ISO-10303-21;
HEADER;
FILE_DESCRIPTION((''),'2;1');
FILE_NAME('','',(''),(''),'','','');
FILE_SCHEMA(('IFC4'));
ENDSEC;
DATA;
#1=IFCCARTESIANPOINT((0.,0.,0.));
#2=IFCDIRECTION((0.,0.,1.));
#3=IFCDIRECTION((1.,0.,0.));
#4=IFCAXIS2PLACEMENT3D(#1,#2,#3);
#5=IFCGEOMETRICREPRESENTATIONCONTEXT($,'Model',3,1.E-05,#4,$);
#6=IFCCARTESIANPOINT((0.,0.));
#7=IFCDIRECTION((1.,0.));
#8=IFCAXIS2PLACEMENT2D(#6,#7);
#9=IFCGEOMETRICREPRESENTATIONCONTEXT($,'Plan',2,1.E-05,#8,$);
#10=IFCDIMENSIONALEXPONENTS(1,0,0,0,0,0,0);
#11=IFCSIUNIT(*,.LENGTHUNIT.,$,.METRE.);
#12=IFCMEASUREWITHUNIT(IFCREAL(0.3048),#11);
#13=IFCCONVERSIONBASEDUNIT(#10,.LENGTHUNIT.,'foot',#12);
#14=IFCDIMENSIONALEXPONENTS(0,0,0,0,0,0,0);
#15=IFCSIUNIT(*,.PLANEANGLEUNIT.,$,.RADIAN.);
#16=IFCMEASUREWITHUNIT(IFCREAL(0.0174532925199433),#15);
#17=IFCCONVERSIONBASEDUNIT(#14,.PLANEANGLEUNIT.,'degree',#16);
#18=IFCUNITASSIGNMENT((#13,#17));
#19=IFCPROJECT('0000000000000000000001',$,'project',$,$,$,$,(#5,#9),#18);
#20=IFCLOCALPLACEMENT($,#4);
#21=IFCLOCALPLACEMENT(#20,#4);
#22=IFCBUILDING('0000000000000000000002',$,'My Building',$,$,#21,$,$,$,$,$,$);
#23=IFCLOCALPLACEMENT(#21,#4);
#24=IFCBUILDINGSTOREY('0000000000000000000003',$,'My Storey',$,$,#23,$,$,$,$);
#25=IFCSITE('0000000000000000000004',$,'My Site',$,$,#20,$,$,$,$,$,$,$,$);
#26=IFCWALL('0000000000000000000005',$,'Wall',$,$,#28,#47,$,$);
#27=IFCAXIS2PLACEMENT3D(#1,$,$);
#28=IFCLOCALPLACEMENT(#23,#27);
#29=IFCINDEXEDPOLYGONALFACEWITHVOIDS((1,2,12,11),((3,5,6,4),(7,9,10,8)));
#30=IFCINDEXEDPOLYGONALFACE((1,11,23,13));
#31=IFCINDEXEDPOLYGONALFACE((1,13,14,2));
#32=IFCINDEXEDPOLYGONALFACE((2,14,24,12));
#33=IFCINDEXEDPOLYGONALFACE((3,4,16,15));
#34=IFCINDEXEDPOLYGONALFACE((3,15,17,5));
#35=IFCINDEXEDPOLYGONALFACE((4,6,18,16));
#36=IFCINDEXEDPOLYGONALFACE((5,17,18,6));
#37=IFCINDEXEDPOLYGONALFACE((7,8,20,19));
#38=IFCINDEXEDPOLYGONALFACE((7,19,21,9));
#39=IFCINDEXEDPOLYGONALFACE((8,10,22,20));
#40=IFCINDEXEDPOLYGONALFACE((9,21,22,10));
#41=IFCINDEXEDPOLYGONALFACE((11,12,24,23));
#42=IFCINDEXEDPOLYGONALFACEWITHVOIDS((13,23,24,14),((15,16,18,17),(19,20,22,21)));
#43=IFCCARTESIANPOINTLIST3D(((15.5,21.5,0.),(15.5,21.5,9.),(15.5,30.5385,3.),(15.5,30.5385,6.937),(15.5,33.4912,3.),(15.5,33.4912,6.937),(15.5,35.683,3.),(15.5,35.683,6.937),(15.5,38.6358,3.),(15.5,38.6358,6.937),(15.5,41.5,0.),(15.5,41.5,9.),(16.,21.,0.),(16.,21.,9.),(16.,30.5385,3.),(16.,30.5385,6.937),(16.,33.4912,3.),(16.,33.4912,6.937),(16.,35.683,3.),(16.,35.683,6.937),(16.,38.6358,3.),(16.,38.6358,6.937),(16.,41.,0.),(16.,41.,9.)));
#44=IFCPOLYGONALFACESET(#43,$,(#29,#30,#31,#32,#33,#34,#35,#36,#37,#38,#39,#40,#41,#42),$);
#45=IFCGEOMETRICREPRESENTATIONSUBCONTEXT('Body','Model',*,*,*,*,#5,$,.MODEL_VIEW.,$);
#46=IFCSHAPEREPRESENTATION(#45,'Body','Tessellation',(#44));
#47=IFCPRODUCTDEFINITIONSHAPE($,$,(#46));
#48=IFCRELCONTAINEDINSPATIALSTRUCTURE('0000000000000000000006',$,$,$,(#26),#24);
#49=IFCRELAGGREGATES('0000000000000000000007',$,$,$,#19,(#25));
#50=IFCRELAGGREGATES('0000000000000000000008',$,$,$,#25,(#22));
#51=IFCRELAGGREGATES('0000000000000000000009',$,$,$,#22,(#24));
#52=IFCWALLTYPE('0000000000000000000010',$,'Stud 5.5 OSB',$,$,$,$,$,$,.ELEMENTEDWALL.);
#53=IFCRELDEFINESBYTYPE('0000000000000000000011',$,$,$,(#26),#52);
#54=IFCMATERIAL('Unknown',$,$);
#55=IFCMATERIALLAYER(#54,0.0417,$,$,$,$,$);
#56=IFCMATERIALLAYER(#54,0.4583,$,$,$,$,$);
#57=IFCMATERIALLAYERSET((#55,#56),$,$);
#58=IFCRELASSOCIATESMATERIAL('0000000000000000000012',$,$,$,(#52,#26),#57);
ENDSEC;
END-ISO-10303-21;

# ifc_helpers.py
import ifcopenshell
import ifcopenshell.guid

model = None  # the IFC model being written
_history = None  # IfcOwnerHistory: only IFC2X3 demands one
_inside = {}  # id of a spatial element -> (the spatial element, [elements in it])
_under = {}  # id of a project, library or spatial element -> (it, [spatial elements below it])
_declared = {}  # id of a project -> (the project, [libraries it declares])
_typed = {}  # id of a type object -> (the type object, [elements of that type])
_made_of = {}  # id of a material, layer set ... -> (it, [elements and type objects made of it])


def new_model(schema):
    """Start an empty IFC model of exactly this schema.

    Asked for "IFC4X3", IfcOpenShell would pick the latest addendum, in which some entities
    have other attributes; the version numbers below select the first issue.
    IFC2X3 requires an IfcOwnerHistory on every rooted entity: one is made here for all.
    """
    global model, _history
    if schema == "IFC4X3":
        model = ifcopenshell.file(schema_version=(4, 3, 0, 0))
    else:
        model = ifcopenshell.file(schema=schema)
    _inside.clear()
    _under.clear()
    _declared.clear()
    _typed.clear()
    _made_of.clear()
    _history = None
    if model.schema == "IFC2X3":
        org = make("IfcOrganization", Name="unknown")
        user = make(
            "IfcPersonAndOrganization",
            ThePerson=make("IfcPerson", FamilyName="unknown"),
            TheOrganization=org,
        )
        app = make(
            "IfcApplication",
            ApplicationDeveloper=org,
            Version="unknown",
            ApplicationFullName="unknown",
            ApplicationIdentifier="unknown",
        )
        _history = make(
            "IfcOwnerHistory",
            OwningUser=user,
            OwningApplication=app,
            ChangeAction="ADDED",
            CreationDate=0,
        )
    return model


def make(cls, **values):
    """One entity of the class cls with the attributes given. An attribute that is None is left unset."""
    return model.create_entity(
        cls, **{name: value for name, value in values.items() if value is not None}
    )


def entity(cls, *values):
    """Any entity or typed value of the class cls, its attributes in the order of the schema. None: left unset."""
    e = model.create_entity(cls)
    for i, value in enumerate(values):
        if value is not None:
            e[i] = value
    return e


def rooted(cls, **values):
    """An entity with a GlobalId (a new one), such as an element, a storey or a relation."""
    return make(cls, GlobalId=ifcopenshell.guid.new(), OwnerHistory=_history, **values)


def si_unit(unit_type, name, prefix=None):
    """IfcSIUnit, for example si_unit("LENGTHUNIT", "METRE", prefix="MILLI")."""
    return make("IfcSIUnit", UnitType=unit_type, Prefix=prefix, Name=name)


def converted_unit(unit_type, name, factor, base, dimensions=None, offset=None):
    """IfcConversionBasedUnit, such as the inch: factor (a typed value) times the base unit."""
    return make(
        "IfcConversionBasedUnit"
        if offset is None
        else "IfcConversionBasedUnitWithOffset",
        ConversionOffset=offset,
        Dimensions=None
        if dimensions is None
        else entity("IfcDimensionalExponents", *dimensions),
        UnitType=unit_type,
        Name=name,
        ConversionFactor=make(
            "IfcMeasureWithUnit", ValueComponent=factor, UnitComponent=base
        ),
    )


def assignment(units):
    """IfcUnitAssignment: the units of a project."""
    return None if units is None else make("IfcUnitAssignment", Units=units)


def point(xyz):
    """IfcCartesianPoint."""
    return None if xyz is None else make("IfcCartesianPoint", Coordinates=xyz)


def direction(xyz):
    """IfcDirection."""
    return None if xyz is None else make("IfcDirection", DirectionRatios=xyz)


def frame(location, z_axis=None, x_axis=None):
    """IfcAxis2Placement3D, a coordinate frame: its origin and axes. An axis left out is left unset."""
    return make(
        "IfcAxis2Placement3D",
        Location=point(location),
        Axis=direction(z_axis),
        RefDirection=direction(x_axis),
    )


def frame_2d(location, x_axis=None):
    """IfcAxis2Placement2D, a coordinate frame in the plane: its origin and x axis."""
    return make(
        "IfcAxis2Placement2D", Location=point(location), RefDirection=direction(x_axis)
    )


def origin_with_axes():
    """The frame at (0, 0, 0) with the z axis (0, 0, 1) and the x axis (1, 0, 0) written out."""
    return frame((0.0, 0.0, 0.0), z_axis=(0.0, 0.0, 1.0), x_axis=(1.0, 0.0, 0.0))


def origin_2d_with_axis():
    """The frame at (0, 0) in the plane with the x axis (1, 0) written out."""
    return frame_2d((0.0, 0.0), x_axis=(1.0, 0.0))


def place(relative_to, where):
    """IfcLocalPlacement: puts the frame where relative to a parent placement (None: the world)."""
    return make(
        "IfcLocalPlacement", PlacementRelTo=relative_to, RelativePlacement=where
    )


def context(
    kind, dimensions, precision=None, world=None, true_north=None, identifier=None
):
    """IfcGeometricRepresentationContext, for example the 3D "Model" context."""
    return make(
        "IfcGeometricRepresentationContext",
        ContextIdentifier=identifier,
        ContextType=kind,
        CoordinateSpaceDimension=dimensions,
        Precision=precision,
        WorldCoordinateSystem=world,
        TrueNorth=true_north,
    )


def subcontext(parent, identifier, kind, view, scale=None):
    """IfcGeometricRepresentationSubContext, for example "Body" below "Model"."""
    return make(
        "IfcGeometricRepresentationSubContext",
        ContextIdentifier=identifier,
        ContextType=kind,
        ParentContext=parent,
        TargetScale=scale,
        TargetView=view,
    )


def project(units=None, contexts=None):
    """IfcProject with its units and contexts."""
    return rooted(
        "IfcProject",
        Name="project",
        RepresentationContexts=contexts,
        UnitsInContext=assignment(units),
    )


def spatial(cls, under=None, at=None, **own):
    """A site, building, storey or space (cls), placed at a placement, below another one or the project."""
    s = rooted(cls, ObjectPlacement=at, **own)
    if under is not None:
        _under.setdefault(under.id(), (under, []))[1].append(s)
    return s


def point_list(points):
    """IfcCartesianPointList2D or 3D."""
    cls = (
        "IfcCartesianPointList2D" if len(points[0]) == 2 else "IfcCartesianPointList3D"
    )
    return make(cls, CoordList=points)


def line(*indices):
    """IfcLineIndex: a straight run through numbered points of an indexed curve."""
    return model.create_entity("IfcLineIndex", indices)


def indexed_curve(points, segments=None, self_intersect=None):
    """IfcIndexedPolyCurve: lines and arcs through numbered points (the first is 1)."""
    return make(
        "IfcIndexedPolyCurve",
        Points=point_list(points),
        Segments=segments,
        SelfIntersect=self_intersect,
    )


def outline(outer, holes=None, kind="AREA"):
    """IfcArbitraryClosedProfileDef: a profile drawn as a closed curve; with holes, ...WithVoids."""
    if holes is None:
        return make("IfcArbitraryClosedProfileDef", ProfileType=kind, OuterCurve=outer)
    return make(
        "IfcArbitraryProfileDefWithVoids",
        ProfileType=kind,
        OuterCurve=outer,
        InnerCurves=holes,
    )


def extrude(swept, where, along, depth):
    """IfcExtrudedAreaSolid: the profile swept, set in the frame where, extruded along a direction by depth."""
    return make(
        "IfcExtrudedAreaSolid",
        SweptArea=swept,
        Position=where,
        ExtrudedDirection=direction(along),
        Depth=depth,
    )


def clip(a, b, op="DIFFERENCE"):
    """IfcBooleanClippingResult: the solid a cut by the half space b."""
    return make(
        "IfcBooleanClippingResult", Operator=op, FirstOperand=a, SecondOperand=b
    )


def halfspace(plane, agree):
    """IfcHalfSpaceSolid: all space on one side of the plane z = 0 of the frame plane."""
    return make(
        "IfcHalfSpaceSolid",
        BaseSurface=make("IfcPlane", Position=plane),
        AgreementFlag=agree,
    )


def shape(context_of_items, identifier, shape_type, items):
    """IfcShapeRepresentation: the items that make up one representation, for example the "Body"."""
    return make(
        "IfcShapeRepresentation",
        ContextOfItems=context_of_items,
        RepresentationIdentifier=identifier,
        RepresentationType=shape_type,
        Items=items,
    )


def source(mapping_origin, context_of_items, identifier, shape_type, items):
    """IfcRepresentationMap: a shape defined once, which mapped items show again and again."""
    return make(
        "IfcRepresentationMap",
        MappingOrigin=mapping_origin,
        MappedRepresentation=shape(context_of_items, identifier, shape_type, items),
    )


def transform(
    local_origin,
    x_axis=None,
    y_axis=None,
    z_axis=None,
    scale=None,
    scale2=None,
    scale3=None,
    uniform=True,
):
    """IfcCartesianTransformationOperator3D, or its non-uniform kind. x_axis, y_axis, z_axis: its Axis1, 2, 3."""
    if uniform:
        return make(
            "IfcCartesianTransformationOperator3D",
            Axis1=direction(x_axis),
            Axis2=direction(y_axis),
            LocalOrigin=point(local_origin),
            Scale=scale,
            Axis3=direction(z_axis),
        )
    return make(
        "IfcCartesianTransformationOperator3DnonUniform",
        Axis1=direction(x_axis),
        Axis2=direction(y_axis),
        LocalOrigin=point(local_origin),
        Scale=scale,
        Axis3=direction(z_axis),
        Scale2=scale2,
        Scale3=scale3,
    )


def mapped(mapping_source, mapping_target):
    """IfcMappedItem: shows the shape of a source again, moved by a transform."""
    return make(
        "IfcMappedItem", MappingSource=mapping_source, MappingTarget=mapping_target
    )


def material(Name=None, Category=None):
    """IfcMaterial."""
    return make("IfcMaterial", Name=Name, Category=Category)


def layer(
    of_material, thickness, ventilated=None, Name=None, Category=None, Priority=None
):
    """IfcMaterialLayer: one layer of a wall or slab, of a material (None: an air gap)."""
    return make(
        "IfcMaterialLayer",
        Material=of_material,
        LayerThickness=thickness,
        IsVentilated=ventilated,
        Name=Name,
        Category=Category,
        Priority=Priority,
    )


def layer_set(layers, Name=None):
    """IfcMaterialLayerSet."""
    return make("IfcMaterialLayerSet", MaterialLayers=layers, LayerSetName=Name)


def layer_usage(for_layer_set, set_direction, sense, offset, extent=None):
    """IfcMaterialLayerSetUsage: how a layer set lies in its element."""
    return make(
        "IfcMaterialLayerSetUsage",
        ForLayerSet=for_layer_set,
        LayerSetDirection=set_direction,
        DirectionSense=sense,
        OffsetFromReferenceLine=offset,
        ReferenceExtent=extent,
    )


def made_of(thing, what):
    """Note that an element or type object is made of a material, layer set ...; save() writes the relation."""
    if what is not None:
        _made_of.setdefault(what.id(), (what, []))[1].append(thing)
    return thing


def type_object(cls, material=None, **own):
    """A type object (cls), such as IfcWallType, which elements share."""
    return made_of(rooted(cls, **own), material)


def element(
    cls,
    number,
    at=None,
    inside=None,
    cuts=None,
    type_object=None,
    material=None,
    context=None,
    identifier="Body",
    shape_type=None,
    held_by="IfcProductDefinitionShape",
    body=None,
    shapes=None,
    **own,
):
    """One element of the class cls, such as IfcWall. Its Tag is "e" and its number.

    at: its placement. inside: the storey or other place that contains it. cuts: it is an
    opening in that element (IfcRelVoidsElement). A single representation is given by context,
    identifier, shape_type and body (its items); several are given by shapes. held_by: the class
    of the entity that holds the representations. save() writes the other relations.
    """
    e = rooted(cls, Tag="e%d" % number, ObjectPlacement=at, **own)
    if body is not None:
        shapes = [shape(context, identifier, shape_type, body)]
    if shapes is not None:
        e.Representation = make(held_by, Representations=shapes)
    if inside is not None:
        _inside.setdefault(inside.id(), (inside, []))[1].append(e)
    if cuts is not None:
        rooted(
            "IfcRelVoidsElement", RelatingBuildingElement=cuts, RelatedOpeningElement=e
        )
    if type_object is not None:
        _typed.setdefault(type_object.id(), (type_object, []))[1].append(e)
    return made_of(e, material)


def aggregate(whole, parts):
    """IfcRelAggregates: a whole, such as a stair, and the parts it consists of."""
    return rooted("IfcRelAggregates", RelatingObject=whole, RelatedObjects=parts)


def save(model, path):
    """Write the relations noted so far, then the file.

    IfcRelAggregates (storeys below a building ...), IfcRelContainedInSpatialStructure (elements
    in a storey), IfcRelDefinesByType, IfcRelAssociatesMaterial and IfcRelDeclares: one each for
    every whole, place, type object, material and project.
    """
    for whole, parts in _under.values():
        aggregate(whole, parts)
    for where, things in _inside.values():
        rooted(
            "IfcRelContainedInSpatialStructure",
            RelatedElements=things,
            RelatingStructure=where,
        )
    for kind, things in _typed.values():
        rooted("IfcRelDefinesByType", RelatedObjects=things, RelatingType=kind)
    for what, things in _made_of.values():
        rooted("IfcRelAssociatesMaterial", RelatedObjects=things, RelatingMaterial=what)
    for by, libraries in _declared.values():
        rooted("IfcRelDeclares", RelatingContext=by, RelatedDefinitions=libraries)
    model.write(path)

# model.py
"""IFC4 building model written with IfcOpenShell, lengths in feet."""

from ifc_helpers import new_model, entity, si_unit, converted_unit, frame, origin_with_axes, origin_2d_with_axis, place, context, subcontext, project, spatial, line, indexed_curve, outline, extrude, clip, halfspace, source, transform, mapped, material, layer, layer_set, layer_usage, type_object, element, save


model = new_model("IFC4")

# Units and contexts
model_context = context("Model", 3, precision=1e-05, world=origin_with_axes())
plan_context = context("Plan", 2, precision=1e-05, world=origin_2d_with_axis())
body_context_1 = subcontext(model_context, "Body", "Model", "MODEL_VIEW")
ifc_project = project(units=[converted_unit("LENGTHUNIT", "foot", entity("IfcReal", 0.3048), si_unit("LENGTHUNIT", "METRE"), dimensions=[1, 0, 0, 0, 0, 0, 0]), converted_unit("PLANEANGLEUNIT", "degree", entity("IfcReal", 0.0174532925199433), si_unit("PLANEANGLEUNIT", "RADIAN"), dimensions=[0, 0, 0, 0, 0, 0, 0])], contexts=[model_context, plan_context])

# Site, building, storey
site_placement = place(None, origin_with_axes())
site = spatial("IfcSite", under=ifc_project, at=site_placement, Name="My Site")
building_placement = place(site_placement, origin_with_axes())
building = spatial("IfcBuilding", under=site, at=building_placement, Name="My Building")
storey_placement = place(building_placement, origin_with_axes())
storey = spatial("IfcBuildingStorey", under=building, at=storey_placement, Name="My Storey")

# Shared definitions
ifc_material = material(Name="Unknown")

# Shared definitions
ifc_layer_1 = layer(ifc_material, 0.0417)
ifc_layer_2 = layer(ifc_material, 0.4583)
ifc_layer_set_1 = layer_set([ifc_layer_1, ifc_layer_2])
wall_type_1 = type_object("IfcWallType", Name="Stud 5.5 OSB", PredefinedType="ELEMENTEDWALL", material=ifc_layer_set_1)
shared_shape_1 = source(origin_with_axes(), body_context_1, "Body", "SweptSolid", [
    extrude(outline(indexed_curve([(0.0, 0.0), (2.9528, 0.0), (2.9528, 3.937), (0.0, 3.937)], segments=[line(1, 2, 3, 4, 1)])), frame((0.0, -1.9685, 0.0), z_axis=(0.0, -1.0, 0.0), x_axis=(1.0, 0.0, 0.0)), (0.0, 0.0, -1.0), 3.937),
])

# Wall, openings
ifc_layer_usage_1 = layer_usage(ifc_layer_set_1, "AXIS2", "POSITIVE", 0.0)
wall_1_placement = place(storey_placement, frame((15.5, 41.5, 0.0), z_axis=(0.0, 0.0, 1.0), x_axis=(0.0, -1.0, 0.0)))
wall_1 = element("IfcWall", 1, at=wall_1_placement, inside=storey, type_object=wall_type_1, material=ifc_layer_usage_1, Name="Wall", context=body_context_1, shape_type="Clipping", body=[
    clip(clip(extrude(outline(indexed_curve([(0.0, 0.0), (0.0, 0.5), (20.5, 0.5), (20.5, 0.0), (0.0, 0.0)], self_intersect=False)), origin_with_axes(), (0.0, 0.0, 1.0), 9.0), halfspace(frame((0.0, 0.0, 0.0), z_axis=(-0.707107, 0.707107, 0.0), x_axis=(0.707107, 0.707107, 0.0)), False)), halfspace(frame((20.0, 0.0, 0.0), z_axis=(0.707107, -0.707107, 0.0), x_axis=(-0.707107, -0.707107, 0.0)), False)),
])
opening_1_placement = place(wall_1_placement, frame((2.8642, 0.0, 3.0), z_axis=(0.0, 0.0, 1.0), x_axis=(1.0, 0.0, 0.0)))
element("IfcOpeningElement", 2, at=opening_1_placement, cuts=wall_1, PredefinedType="OPENING", context=body_context_1, shape_type="MappedRepresentation", body=[
    mapped(shared_shape_1, transform((0.0, 0.0, 0.0), x_axis=(1.0, 0.0, 0.0), y_axis=(0.0, 1.0, 0.0), z_axis=(0.0, 0.0, 1.0), scale=1.0)),
])
opening_2_placement = place(wall_1_placement, frame((8.0088, 0.0, 3.0), z_axis=(0.0, 0.0, 1.0), x_axis=(1.0, 0.0, 0.0)))
element("IfcOpeningElement", 3, at=opening_2_placement, cuts=wall_1, PredefinedType="OPENING", context=body_context_1, shape_type="MappedRepresentation", body=[
    mapped(shared_shape_1, transform((0.0, 0.0, 0.0), x_axis=(1.0, 0.0, 0.0), y_axis=(0.0, 1.0, 0.0), z_axis=(0.0, 0.0, 1.0), scale=1.0)),
])

save(model, "model.ifc")
